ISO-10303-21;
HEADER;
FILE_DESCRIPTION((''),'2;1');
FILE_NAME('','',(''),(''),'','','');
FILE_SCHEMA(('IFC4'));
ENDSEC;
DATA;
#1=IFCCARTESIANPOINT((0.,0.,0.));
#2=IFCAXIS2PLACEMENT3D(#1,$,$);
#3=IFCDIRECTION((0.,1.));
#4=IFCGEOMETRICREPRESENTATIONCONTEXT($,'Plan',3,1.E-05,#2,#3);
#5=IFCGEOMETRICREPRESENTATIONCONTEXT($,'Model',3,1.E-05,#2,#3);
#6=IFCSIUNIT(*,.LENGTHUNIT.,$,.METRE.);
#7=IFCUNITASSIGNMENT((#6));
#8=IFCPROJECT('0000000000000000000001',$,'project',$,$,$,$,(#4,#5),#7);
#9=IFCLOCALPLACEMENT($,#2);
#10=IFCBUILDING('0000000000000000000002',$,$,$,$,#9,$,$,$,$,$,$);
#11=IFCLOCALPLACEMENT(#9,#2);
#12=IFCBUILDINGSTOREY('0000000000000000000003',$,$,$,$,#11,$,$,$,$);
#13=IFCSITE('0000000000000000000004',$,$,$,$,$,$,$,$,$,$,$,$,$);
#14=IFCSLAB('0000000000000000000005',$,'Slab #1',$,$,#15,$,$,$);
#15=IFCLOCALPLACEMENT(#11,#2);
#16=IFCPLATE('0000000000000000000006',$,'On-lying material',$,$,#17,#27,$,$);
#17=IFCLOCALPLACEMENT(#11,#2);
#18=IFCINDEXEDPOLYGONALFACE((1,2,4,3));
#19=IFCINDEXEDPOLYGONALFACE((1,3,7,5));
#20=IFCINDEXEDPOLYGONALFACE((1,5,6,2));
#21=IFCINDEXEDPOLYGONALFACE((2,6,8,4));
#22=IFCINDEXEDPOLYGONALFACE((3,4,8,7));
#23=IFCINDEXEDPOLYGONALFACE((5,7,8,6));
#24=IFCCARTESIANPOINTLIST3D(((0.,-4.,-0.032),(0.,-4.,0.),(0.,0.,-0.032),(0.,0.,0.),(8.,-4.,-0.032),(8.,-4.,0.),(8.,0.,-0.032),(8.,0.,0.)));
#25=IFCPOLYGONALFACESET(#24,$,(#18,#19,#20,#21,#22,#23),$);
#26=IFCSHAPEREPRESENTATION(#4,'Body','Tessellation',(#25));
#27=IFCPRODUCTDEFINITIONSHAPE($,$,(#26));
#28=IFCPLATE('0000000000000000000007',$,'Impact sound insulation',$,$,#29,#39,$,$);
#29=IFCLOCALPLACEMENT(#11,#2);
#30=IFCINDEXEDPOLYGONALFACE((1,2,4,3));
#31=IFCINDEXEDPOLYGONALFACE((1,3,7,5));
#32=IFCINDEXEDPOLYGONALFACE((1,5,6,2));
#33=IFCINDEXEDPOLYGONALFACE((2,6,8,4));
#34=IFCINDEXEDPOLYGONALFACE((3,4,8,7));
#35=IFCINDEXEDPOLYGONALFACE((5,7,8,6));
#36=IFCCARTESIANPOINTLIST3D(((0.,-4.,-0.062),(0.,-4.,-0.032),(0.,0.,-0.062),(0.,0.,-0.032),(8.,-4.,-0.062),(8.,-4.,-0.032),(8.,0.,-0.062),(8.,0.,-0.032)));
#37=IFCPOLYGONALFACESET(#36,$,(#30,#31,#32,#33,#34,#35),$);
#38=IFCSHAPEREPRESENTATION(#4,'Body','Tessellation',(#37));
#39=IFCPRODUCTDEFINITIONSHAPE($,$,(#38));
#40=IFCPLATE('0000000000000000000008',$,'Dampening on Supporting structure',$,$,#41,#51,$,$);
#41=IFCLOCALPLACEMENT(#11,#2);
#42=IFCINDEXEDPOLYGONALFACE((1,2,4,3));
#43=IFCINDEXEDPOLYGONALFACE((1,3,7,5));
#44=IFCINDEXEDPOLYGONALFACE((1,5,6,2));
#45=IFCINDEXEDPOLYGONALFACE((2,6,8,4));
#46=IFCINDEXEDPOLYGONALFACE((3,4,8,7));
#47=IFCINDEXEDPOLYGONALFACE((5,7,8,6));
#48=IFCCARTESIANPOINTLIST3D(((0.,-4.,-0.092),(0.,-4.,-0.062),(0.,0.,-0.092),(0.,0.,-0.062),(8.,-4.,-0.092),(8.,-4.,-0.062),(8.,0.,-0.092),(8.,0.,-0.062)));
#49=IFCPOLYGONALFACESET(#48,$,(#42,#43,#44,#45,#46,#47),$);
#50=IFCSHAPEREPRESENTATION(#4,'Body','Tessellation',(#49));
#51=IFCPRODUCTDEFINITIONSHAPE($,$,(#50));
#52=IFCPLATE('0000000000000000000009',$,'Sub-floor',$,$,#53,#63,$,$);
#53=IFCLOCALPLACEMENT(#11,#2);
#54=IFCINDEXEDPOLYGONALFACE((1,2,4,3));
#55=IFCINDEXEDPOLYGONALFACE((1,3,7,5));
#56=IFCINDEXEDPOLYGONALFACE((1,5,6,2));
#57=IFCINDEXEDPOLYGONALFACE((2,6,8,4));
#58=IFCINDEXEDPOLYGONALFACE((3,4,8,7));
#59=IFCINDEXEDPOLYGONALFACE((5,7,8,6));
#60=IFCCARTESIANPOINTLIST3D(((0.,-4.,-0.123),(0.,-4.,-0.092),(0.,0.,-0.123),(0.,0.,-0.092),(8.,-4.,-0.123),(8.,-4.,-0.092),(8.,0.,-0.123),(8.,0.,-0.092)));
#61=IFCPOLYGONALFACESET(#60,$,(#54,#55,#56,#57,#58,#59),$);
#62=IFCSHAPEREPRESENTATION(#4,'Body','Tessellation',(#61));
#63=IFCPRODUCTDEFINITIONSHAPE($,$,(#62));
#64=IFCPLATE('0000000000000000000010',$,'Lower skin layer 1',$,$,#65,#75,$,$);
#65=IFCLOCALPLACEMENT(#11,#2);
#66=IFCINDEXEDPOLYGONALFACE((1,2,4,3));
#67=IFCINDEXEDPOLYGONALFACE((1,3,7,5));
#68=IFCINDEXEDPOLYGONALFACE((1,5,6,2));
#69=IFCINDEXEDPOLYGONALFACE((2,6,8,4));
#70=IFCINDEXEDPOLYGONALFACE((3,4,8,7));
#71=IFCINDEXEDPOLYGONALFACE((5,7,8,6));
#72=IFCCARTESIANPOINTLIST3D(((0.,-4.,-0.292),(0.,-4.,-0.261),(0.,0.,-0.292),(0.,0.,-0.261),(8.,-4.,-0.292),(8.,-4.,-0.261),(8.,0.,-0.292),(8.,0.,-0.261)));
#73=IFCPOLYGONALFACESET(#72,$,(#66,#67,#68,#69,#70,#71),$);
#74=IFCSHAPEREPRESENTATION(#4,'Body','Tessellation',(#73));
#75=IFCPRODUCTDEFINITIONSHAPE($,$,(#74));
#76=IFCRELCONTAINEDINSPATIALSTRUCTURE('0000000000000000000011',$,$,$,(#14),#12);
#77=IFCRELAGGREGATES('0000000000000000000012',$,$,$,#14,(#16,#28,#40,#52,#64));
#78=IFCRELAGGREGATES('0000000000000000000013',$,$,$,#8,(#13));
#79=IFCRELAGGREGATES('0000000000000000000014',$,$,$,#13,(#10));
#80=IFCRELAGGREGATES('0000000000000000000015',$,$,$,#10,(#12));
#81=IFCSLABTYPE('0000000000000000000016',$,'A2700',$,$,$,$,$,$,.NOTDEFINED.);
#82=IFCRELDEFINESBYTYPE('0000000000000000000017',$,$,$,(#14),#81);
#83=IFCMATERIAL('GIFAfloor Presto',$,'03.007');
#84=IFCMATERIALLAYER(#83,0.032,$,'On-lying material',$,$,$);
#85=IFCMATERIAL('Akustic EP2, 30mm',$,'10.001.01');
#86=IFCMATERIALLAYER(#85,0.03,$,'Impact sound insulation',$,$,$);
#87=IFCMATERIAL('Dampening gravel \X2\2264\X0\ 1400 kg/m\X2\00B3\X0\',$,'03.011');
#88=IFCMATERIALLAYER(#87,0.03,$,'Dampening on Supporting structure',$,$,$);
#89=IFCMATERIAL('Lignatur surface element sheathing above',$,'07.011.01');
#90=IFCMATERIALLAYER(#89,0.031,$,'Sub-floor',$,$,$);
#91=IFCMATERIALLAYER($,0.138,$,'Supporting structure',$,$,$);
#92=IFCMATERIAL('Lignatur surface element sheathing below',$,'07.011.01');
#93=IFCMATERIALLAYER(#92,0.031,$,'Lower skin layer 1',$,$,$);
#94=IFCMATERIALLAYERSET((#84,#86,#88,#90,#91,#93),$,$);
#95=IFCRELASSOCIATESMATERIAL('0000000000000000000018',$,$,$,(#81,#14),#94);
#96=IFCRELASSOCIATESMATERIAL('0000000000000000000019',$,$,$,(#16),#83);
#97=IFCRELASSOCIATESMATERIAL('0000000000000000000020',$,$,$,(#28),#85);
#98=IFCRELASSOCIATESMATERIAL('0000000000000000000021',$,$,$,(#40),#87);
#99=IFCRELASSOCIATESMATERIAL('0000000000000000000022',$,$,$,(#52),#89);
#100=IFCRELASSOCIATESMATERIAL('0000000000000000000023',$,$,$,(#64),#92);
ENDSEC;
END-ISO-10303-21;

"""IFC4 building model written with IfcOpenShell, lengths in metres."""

from ifc_helpers import new_model, si_unit, direction, frame, frame_2d, origin, origin_with_axes, place, context, project, spatial, rectangle, extrude, material, layer, layer_set, type_object, element, aggregate, save


model = new_model("IFC4")

# Units and contexts
plan_context = context("Plan", 3, precision=1e-05, world=origin(), true_north=direction((0.0, 1.0)))
model_context = context("Model", 3, precision=1e-05, world=origin(), true_north=direction((0.0, 1.0)))
ifc_project = project(units=[si_unit("LENGTHUNIT", "METRE")], contexts=[plan_context, model_context])

# Site, building, storey
site = spatial("IfcSite", under=ifc_project)
building_placement = place(None, origin())
building = spatial("IfcBuilding", under=site, at=building_placement)
storey_placement = place(building_placement, origin())
storey = spatial("IfcBuildingStorey", under=building, at=storey_placement)

# Slab, plates
ifc_material_1 = material(Name="GIFAfloor Presto", Category="03.007")
ifc_layer_1 = layer(ifc_material_1, 0.032, Name="On-lying material")
ifc_material_2 = material(Name="Akustic EP2, 30mm", Category="10.001.01")
ifc_layer_2 = layer(ifc_material_2, 0.03, Name="Impact sound insulation")
ifc_material_3 = material(Name="Dampening gravel ≤ 1400 kg/m³", Category="03.011")
ifc_layer_3 = layer(ifc_material_3, 0.03, Name="Dampening on Supporting structure")
ifc_material_4 = material(Name="Lignatur surface element sheathing above", Category="07.011.01")
ifc_layer_4 = layer(ifc_material_4, 0.031, Name="Sub-floor")
ifc_layer_5 = layer(None, 0.138, Name="Supporting structure")
ifc_material_5 = material(Name="Lignatur surface element sheathing below", Category="07.011.01")
ifc_layer_6 = layer(ifc_material_5, 0.031, Name="Lower skin layer 1")
ifc_layer_set = layer_set([ifc_layer_1, ifc_layer_2, ifc_layer_3, ifc_layer_4, ifc_layer_5, ifc_layer_6])
slab_type = type_object("IfcSlabType", Name="A2700", PredefinedType="NOTDEFINED", material=ifc_layer_set)
slab_placement = place(None, frame((0.0, 0.0, 0.0), z_axis=(0.0, 0.0, -1.0), x_axis=(1.0, 0.0, 0.0)))
slab = element("IfcSlab", 1, at=slab_placement, inside=storey, type_object=slab_type, material=ifc_layer_set, Name="Slab #1")
plate_1_placement = place(slab_placement, origin())
plate_1 = element("IfcPlate", 2, at=plate_1_placement, material=ifc_material_1, Name="On-lying material", context=plan_context, shape_type="SweptSolid", body=[
    extrude(rectangle(XDim=8.0, YDim=4.0, at=frame_2d((4.0, 2.0), x_axis=(1.0, 0.0))), origin_with_axes(), (0.0, 0.0, 1.0), 0.032),
])
plate_2_placement = place(slab_placement, origin())
plate_2 = element("IfcPlate", 3, at=plate_2_placement, material=ifc_material_2, Name="Impact sound insulation", context=plan_context, shape_type="SweptSolid", body=[
    extrude(rectangle(XDim=8.0, YDim=4.0, at=frame_2d((4.0, 2.0), x_axis=(1.0, 0.0))), frame((0.0, 0.0, 0.032), z_axis=(0.0, 0.0, 1.0), x_axis=(1.0, 0.0, 0.0)), (0.0, 0.0, 1.0), 0.03),
])
plate_3_placement = place(slab_placement, origin())
plate_3 = element("IfcPlate", 4, at=plate_3_placement, material=ifc_material_3, Name="Dampening on Supporting structure", context=plan_context, shape_type="SweptSolid", body=[
    extrude(rectangle(XDim=8.0, YDim=4.0, at=frame_2d((4.0, 2.0), x_axis=(1.0, 0.0))), frame((0.0, 0.0, 0.062), z_axis=(0.0, 0.0, 1.0), x_axis=(1.0, 0.0, 0.0)), (0.0, 0.0, 1.0), 0.03),
])
plate_4_placement = place(slab_placement, origin())
plate_4 = element("IfcPlate", 5, at=plate_4_placement, material=ifc_material_4, Name="Sub-floor", context=plan_context, shape_type="SweptSolid", body=[
    extrude(rectangle(XDim=8.0, YDim=4.0, at=frame_2d((4.0, 2.0), x_axis=(1.0, 0.0))), frame((0.0, 0.0, 0.092), z_axis=(0.0, 0.0, 1.0), x_axis=(1.0, 0.0, 0.0)), (0.0, 0.0, 1.0), 0.031),
])
plate_5_placement = place(slab_placement, origin())
plate_5 = element("IfcPlate", 6, at=plate_5_placement, material=ifc_material_5, Name="Lower skin layer 1", context=plan_context, shape_type="SweptSolid", body=[
    extrude(rectangle(XDim=8.0, YDim=4.0, at=frame_2d((4.0, 2.0), x_axis=(1.0, 0.0))), frame((0.0, 0.0, 0.261), z_axis=(0.0, 0.0, 1.0), x_axis=(1.0, 0.0, 0.0)), (0.0, 0.0, 1.0), 0.031),
])
aggregate(slab, [plate_1, plate_2, plate_3, plate_4, plate_5])

save(model, "model.ifc")
